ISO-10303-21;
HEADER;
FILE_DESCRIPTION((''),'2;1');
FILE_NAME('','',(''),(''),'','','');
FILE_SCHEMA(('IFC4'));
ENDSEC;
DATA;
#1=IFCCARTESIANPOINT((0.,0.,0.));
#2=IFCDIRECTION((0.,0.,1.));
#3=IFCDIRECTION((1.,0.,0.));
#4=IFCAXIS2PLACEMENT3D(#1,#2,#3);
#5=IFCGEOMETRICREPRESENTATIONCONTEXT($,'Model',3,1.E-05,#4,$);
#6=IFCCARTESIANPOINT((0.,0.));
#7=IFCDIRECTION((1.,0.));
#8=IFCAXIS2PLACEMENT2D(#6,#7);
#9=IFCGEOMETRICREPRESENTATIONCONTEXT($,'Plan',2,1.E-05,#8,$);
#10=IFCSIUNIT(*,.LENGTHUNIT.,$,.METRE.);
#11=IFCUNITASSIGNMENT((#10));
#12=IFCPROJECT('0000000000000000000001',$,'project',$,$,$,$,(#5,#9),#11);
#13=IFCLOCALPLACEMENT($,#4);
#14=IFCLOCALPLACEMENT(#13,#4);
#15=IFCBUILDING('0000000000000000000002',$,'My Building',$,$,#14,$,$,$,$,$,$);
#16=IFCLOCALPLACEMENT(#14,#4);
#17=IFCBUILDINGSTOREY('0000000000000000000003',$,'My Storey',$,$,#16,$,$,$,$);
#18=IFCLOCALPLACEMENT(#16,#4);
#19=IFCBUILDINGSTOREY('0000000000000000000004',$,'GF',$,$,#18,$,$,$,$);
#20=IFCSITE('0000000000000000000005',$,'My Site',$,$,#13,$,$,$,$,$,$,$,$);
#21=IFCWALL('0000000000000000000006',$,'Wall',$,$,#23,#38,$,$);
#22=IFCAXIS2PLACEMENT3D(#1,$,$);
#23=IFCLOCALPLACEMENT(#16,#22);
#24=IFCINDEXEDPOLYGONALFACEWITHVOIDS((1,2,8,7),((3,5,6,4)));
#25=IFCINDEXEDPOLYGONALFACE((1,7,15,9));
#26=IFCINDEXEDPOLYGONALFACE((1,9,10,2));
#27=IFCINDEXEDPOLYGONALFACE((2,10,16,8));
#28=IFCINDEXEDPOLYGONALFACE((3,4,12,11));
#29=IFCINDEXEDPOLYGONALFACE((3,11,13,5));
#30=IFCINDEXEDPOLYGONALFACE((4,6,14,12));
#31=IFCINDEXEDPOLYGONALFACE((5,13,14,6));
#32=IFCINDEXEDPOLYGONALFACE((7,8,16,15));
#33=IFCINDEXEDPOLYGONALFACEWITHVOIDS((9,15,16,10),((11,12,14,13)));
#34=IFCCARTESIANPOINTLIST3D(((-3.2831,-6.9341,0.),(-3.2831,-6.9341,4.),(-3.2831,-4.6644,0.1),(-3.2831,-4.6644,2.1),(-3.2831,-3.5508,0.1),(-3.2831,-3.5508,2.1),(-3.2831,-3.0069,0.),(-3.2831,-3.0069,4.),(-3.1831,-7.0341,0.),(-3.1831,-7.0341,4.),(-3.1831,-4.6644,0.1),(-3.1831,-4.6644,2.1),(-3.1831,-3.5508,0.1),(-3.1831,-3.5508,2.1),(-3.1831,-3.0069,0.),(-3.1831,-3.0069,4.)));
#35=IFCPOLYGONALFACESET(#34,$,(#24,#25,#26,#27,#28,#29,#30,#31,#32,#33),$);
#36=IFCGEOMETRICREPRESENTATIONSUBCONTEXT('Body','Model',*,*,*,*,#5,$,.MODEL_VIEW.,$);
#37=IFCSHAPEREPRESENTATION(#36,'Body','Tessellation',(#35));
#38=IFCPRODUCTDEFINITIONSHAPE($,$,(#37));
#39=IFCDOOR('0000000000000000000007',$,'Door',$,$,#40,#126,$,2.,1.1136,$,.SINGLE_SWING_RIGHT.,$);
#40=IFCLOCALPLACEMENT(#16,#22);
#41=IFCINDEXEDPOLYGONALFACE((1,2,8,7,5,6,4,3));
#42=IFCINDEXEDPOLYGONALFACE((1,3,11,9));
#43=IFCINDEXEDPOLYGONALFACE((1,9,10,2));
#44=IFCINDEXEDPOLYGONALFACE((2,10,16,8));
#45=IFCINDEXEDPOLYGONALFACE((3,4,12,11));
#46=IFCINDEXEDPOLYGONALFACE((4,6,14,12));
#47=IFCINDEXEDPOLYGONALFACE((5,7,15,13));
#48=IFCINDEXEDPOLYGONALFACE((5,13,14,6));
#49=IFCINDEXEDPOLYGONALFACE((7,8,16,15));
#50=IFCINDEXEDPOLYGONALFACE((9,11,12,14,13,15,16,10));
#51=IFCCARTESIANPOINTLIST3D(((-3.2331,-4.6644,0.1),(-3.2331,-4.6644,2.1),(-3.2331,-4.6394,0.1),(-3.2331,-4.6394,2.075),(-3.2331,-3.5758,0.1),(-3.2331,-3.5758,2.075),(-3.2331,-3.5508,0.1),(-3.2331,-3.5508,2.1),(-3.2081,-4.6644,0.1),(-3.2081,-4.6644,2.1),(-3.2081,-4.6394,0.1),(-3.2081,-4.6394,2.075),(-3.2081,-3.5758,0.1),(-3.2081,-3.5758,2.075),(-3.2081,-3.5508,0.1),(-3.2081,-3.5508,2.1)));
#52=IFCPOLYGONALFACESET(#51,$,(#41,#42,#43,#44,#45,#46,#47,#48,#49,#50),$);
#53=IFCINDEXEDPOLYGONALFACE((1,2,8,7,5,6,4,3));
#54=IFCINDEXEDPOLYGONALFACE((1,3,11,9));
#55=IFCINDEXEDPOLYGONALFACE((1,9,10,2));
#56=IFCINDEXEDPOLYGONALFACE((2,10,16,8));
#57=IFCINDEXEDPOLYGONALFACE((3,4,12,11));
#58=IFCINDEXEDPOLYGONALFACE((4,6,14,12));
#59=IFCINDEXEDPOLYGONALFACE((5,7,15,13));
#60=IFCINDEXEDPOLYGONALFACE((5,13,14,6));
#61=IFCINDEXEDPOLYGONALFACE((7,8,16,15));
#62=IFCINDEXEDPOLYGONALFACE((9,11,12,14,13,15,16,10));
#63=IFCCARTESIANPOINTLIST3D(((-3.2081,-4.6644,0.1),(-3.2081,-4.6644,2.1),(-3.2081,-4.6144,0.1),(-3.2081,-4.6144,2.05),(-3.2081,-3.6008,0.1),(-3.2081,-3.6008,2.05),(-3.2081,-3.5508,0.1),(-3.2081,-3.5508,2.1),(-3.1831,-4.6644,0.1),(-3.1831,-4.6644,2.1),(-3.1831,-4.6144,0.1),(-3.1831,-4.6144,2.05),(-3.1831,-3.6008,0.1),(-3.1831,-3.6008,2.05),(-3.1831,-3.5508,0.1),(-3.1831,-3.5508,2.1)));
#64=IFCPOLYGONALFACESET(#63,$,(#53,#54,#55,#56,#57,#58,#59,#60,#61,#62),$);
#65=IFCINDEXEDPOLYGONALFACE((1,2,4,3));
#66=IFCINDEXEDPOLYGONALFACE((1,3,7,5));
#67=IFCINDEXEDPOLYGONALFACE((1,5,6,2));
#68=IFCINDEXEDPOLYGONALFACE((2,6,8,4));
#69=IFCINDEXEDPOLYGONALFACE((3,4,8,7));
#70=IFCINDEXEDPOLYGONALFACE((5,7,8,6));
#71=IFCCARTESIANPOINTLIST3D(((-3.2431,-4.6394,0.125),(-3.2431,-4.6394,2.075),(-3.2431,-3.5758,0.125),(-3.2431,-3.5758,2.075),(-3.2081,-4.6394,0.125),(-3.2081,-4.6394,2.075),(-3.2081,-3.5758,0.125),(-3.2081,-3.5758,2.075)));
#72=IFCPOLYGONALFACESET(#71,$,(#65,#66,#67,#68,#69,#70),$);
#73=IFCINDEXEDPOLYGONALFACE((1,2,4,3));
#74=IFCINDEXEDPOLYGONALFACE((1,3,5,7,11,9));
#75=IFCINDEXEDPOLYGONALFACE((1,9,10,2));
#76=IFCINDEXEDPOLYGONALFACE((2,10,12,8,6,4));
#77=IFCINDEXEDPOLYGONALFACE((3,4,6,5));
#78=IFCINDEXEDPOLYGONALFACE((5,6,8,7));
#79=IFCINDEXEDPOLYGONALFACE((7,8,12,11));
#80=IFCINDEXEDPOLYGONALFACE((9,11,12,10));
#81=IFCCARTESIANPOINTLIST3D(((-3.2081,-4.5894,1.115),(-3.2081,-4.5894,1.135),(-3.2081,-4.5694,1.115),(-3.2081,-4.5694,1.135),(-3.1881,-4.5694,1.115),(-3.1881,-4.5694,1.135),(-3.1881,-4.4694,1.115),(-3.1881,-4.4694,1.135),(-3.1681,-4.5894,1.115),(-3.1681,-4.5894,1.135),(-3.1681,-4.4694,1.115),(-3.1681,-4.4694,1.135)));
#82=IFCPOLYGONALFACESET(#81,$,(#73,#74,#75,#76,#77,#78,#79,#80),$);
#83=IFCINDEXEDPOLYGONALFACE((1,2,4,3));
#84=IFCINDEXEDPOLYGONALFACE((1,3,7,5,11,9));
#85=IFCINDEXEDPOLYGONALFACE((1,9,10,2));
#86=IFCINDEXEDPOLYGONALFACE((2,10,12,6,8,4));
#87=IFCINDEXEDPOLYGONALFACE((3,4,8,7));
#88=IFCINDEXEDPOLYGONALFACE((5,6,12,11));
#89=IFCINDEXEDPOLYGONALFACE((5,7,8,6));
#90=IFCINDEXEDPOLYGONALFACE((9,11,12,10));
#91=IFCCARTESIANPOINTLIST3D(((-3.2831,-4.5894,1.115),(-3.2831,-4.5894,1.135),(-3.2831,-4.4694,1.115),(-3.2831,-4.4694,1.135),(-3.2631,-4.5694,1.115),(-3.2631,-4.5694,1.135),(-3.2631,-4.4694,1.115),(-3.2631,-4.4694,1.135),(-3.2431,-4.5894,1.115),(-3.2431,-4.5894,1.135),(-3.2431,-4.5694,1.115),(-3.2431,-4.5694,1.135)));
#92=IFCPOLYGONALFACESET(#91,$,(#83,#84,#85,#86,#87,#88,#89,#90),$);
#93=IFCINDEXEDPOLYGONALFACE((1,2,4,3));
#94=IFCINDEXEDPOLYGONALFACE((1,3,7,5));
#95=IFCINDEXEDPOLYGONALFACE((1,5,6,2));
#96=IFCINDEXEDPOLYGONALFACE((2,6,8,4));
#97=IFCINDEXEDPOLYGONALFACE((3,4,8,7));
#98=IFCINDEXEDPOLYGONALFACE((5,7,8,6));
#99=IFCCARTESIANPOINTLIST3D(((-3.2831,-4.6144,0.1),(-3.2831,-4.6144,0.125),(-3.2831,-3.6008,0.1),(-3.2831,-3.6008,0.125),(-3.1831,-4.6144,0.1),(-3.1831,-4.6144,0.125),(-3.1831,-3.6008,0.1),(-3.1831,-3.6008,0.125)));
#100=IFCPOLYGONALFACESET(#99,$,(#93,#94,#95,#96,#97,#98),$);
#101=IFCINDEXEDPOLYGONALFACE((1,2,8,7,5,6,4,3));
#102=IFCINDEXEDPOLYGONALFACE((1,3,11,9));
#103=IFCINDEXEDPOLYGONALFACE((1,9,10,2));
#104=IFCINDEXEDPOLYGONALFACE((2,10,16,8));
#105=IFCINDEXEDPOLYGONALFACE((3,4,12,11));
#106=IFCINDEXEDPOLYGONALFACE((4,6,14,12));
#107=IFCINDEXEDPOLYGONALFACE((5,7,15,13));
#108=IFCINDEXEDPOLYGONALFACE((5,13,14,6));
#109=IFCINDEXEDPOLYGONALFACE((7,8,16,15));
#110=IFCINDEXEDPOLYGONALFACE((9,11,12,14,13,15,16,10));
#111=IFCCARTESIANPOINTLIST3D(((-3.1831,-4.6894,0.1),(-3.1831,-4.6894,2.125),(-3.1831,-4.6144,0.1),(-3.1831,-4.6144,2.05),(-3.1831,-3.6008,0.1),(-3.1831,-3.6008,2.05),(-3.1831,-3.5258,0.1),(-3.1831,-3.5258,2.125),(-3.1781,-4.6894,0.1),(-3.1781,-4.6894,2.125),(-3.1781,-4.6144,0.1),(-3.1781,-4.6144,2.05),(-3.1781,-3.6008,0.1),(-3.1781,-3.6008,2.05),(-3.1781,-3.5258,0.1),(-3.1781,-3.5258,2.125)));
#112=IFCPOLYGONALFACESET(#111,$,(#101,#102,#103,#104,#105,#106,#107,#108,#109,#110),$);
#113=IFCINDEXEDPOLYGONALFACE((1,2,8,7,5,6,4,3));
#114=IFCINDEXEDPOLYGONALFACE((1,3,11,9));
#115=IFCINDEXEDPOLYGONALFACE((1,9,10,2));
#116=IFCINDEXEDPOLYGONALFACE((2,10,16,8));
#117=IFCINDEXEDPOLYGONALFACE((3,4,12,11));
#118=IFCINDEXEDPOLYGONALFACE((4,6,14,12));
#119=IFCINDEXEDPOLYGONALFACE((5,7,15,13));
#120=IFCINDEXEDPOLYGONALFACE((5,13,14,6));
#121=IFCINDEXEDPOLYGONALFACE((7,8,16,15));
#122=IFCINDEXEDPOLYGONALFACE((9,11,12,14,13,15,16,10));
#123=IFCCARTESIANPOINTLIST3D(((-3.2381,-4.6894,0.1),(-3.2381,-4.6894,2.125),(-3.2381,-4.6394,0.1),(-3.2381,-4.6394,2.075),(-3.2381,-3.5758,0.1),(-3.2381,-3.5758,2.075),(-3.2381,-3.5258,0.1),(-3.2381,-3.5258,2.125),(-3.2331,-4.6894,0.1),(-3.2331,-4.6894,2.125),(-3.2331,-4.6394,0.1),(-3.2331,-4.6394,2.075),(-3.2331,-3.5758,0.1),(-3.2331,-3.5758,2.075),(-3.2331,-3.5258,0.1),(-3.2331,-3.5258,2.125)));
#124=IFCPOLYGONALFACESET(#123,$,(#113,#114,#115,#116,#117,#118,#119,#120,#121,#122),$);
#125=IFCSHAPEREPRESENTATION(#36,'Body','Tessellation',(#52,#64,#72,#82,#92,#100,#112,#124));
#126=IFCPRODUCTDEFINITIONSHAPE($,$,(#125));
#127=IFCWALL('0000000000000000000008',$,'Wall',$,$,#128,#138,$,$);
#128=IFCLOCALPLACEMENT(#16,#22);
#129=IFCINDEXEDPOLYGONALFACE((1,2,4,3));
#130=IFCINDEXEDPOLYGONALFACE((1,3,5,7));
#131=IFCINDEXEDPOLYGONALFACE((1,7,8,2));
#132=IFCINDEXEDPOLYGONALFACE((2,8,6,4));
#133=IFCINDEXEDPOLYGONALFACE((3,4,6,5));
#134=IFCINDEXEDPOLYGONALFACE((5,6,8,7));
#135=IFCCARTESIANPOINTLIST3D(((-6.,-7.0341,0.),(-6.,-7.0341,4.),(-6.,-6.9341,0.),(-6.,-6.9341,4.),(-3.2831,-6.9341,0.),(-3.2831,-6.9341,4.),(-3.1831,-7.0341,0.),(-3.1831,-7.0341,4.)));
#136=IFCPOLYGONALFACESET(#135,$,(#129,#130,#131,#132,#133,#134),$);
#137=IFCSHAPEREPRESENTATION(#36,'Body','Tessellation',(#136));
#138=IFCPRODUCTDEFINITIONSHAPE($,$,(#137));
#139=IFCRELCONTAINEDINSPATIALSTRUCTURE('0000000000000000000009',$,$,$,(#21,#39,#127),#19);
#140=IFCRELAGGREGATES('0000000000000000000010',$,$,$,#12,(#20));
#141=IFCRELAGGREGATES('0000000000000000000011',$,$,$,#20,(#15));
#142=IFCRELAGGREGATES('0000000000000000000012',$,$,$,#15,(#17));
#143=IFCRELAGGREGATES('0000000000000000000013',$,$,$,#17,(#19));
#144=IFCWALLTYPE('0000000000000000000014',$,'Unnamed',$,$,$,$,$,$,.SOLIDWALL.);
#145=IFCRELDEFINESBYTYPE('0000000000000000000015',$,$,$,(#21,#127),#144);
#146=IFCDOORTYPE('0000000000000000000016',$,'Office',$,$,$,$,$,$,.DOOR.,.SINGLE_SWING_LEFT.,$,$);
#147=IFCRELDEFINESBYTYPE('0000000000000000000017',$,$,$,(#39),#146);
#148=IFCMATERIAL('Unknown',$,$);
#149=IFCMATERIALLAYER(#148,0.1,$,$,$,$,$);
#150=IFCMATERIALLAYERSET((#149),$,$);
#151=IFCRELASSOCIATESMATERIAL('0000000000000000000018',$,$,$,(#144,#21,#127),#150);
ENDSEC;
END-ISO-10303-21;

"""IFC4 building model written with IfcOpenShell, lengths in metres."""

from ifc_helpers import new_model, entity, si_unit, frame, origin_with_axes, origin_2d_with_axis, place, context, subcontext, project, spatial, line, indexed_curve, outline, extrude, shape, source, transform, mapped, material, layer, layer_set, layer_usage, type_object, type_shapes, element, fill, save


model = new_model("IFC4")

# Units and contexts
model_context = context("Model", 3, precision=1e-05, world=origin_with_axes())
plan_context = context("Plan", 2, precision=1e-05, world=origin_2d_with_axis())
body_context_1 = subcontext(model_context, "Body", "Model", "MODEL_VIEW")
body_context_2 = subcontext(plan_context, "Body", "Plan", "PLAN_VIEW")
ifc_project = project(units=[si_unit("LENGTHUNIT", "METRE")], contexts=[model_context, plan_context])

# Site, building, storeys
site_placement = place(None, origin_with_axes())
site = spatial("IfcSite", under=ifc_project, at=site_placement, Name="My Site")
building_placement = place(site_placement, origin_with_axes())
building = spatial("IfcBuilding", under=site, at=building_placement, Name="My Building")
storey_1_placement = place(building_placement, origin_with_axes())
storey_1 = spatial("IfcBuildingStorey", under=building, at=storey_1_placement, Name="My Storey")
storey_2_placement = place(storey_1_placement, origin_with_axes())
storey_2 = spatial("IfcBuildingStorey", under=storey_1, at=storey_2_placement, Name="GF")

# Shared definitions
ifc_material = material(Name="Unknown")

# Shared definitions
ifc_layer = layer(ifc_material, 0.1)
ifc_layer_set = layer_set([ifc_layer])
wall_type = type_object("IfcWallType", Name="Unnamed", PredefinedType="SOLIDWALL", material=ifc_layer_set)

# Wall, opening, door
ifc_layer_usage_1 = layer_usage(ifc_layer_set, "AXIS2", "POSITIVE", 0.0)
wall_1_placement = place(storey_2_placement, frame((-3.2831, -2.9069, 0.0), z_axis=(0.0, 0.0, 1.0), x_axis=(0.0, -1.0, 0.0)))
wall_1 = element("IfcWall", 1, at=wall_1_placement, inside=storey_2, type_object=wall_type, material=ifc_layer_usage_1, Name="Wall", context=body_context_1, shape_type="SweptSolid", body=[
    extrude(outline(indexed_curve([(0.1, 0.0), (0.1, 0.1), (4.1272, 0.1), (4.0272, 0.0)], segments=[line(1, 2, 3, 4, 1)])), origin_with_axes(), (0.0, 0.0, 1.0), 4.0),
])
shared_shape_1 = source(origin_with_axes(), body_context_1, "Body", "SweptSolid", [
    extrude(outline(indexed_curve([(0.0, 0.0), (1.1136, 0.0), (1.1136, 2.0), (0.0, 2.0)], segments=[line(1, 2, 3, 4, 1)])), frame((0.0, -0.6, 0.0), z_axis=(0.0, -1.0, 0.0), x_axis=(1.0, 0.0, 0.0)), (0.0, 0.0, -1.0), 1.2),
])
opening_1_placement = place(wall_1_placement, frame((1.7574, 0.1, 0.1), z_axis=(0.0, 0.0, 1.0), x_axis=(-1.0, 0.0, 0.0)))
opening_1 = element("IfcOpeningElement", 2, at=opening_1_placement, cuts=wall_1, PredefinedType="OPENING", context=body_context_1, shape_type="MappedRepresentation", body=[
    mapped(shared_shape_1, transform((0.0, 0.0, 0.0), x_axis=(1.0, 0.0, 0.0), y_axis=(0.0, 1.0, 0.0), z_axis=(0.0, 0.0, 1.0), scale=1.0)),
])
door_type_1 = type_object("IfcDoorType", Name="Office", OperationType="SINGLE_SWING_LEFT", PredefinedType="DOOR")
shared_shape_2 = source(origin_with_axes(), body_context_1, "Body", "SweptSolid", [
    extrude(outline(indexed_curve([(0.0, 0.0), (0.0, 2.0), (1.1136, 2.0), (1.1136, 0.0), (1.0886, 0.0), (1.0886, 1.975), (0.025, 1.975), (0.025, 0.0)], segments=[line(1, 2, 3, 4, 5, 6, 7, 8, 1)])), frame((0.0, 0.025, 0.0), z_axis=(0.0, -1.0, 0.0), x_axis=(1.0, 0.0, 0.0)), (0.0, 0.0, -1.0), 0.025),
    extrude(outline(indexed_curve([(0.0, 0.0), (0.0, 2.0), (1.1136, 2.0), (1.1136, 0.0), (1.0636, 0.0), (1.0636, 1.95), (0.05, 1.95), (0.05, 0.0)], segments=[line(1, 2, 3, 4, 5, 6, 7, 8, 1)])), frame((0.0, 0.0, 0.0), z_axis=(0.0, -1.0, 0.0), x_axis=(1.0, 0.0, 0.0)), (0.0, 0.0, -1.0), 0.025),
    extrude(outline(indexed_curve([(0.0, 0.0), (1.0636, 0.0), (1.0636, 0.035), (0.0, 0.035)], segments=[line(1, 2, 3, 4, 1)])), frame((0.025, 0.025, 0.025), z_axis=(0.0, 0.0, 1.0), x_axis=(1.0, 0.0, 0.0)), (0.0, 0.0, 1.0), 1.95),
    extrude(outline(indexed_curve([(0.0, 0.0), (0.0, -0.04), (0.12, -0.04), (0.12, -0.02), (0.02, -0.02), (0.02, 0.0)], segments=[line(1, 2, 3, 4, 5, 6, 1)])), frame((0.075, 0.025, 1.015), z_axis=(0.0, 0.0, 1.0), x_axis=(1.0, 0.0, 0.0)), (0.0, 0.0, 1.0), 0.02),
    extrude(outline(indexed_curve([(0.0, 0.0), (0.0, 0.04), (0.12, 0.04), (0.12, 0.02), (0.02, 0.02), (0.02, 0.0)], segments=[line(1, 2, 3, 4, 5, 6, 1)])), frame((0.075, 0.06, 1.015), z_axis=(0.0, 0.0, 1.0), x_axis=(1.0, 0.0, 0.0)), (0.0, 0.0, 1.0), 0.02),
    extrude(outline(indexed_curve([(0.0, 0.0), (1.0136, 0.0), (1.0136, 0.1), (0.0, 0.1)], segments=[line(1, 2, 3, 4, 1)])), frame((0.05, 0.0, 0.0), z_axis=(0.0, 0.0, 1.0), x_axis=(1.0, 0.0, 0.0)), (0.0, 0.0, 1.0), 0.025),
    extrude(outline(indexed_curve([(0.0, 0.0), (0.0, 2.025), (1.1636, 2.025), (1.1636, 0.0), (1.0886, 0.0), (1.0886, 1.95), (0.075, 1.95), (0.075, 0.0)], segments=[line(1, 2, 3, 4, 5, 6, 7, 8, 1)])), frame((-0.025, -0.005, 0.0), z_axis=(0.0, -1.0, 0.0), x_axis=(1.0, 0.0, 0.0)), (0.0, 0.0, -1.0), 0.005),
    extrude(outline(indexed_curve([(0.0, 0.0), (0.0, 2.025), (1.1636, 2.025), (1.1636, 0.0), (1.1136, 0.0), (1.1136, 1.975), (0.05, 1.975), (0.05, 0.0)], segments=[line(1, 2, 3, 4, 5, 6, 7, 8, 1)])), frame((-0.025, 0.05, 0.0), z_axis=(0.0, -1.0, 0.0), x_axis=(1.0, 0.0, 0.0)), (0.0, 0.0, -1.0), 0.005),
])
shared_shape_3 = source(origin_with_axes(), body_context_2, "Body", "Curve2D", [
    entity("IfcIndexedPolyCurve", entity("IfcCartesianPointList2D", [[0.0, 0.0], [0.0, 0.05], [0.025, 0.05], [0.025, 0.025], [0.05, 0.025], [0.05, 0.0]]), [entity("IfcLineIndex", [1, 2, 3, 4, 5, 6, 1])]),
    entity("IfcIndexedPolyCurve", entity("IfcCartesianPointList2D", [[1.1136, 0.0], [1.1136, 0.05], [1.0886, 0.05], [1.0886, 0.025], [1.0636, 0.025], [1.0636, 0.0]]), [entity("IfcLineIndex", [1, 2, 3, 4, 5, 6, 1])]),
    entity("IfcTrimmedCurve", entity("IfcEllipse", entity("IfcAxis2Placement2D", entity("IfcCartesianPoint", [1.0536, 0.05]), entity("IfcDirection", [1.0, 0.0])), 1.0286, 1.0636), [entity("IfcCartesianPoint", [1.0536, 1.1136])], [entity("IfcCartesianPoint", [0.025, 0.05])], True, "CARTESIAN"),
    entity("IfcIndexedPolyCurve", entity("IfcCartesianPointList2D", [[1.0886, 0.05], [1.0536, 0.05], [1.0536, 1.1136], [1.0886, 1.1136]]), [entity("IfcLineIndex", [1, 2, 3, 4, 1])]),
])
type_shapes(door_type_1, [shared_shape_2, shared_shape_3])
door_1_placement = place(opening_1_placement, frame((0.0, 0.0, 0.0), z_axis=(0.0, 0.0, 1.0), x_axis=(1.0, 0.0, 0.0)))
door_1 = element("IfcDoor", 3, at=door_1_placement, inside=storey_2, type_object=door_type_1, Name="Door", OperationType="SINGLE_SWING_RIGHT", OverallHeight=2.0, OverallWidth=1.1136, shapes=[
    shape(body_context_1, "Body", "MappedRepresentation", [mapped(shared_shape_2, transform((0.0, 0.0, 0.0), x_axis=(1.0, 0.0, 0.0), y_axis=(0.0, 1.0, 0.0), z_axis=(0.0, 0.0, 1.0), scale=1.0))]),
    shape(body_context_2, "Body", "MappedRepresentation", [mapped(shared_shape_3, transform((0.0, 0.0, 0.0), x_axis=(1.0, 0.0, 0.0), y_axis=(0.0, 1.0, 0.0), z_axis=(0.0, 0.0, 1.0), scale=1.0))]),
])
fill(opening_1, door_1)

# Wall
ifc_layer_usage_2 = layer_usage(ifc_layer_set, "AXIS2", "POSITIVE", 0.0)
wall_2_placement = place(storey_2_placement, frame((-3.2831, -6.9341, 0.0), z_axis=(0.0, 0.0, 1.0), x_axis=(-1.0, 0.0, 0.0)))
element("IfcWall", 4, at=wall_2_placement, inside=storey_2, type_object=wall_type, material=ifc_layer_usage_2, Name="Wall", context=body_context_1, shape_type="SweptSolid", body=[
    extrude(outline(indexed_curve([(0.0, 0.0), (-0.1, 0.1), (2.7169, 0.1), (2.7169, 0.0)], segments=[line(1, 2, 3, 4, 1)])), origin_with_axes(), (0.0, 0.0, 1.0), 4.0),
])

save(model, "model.ifc")
